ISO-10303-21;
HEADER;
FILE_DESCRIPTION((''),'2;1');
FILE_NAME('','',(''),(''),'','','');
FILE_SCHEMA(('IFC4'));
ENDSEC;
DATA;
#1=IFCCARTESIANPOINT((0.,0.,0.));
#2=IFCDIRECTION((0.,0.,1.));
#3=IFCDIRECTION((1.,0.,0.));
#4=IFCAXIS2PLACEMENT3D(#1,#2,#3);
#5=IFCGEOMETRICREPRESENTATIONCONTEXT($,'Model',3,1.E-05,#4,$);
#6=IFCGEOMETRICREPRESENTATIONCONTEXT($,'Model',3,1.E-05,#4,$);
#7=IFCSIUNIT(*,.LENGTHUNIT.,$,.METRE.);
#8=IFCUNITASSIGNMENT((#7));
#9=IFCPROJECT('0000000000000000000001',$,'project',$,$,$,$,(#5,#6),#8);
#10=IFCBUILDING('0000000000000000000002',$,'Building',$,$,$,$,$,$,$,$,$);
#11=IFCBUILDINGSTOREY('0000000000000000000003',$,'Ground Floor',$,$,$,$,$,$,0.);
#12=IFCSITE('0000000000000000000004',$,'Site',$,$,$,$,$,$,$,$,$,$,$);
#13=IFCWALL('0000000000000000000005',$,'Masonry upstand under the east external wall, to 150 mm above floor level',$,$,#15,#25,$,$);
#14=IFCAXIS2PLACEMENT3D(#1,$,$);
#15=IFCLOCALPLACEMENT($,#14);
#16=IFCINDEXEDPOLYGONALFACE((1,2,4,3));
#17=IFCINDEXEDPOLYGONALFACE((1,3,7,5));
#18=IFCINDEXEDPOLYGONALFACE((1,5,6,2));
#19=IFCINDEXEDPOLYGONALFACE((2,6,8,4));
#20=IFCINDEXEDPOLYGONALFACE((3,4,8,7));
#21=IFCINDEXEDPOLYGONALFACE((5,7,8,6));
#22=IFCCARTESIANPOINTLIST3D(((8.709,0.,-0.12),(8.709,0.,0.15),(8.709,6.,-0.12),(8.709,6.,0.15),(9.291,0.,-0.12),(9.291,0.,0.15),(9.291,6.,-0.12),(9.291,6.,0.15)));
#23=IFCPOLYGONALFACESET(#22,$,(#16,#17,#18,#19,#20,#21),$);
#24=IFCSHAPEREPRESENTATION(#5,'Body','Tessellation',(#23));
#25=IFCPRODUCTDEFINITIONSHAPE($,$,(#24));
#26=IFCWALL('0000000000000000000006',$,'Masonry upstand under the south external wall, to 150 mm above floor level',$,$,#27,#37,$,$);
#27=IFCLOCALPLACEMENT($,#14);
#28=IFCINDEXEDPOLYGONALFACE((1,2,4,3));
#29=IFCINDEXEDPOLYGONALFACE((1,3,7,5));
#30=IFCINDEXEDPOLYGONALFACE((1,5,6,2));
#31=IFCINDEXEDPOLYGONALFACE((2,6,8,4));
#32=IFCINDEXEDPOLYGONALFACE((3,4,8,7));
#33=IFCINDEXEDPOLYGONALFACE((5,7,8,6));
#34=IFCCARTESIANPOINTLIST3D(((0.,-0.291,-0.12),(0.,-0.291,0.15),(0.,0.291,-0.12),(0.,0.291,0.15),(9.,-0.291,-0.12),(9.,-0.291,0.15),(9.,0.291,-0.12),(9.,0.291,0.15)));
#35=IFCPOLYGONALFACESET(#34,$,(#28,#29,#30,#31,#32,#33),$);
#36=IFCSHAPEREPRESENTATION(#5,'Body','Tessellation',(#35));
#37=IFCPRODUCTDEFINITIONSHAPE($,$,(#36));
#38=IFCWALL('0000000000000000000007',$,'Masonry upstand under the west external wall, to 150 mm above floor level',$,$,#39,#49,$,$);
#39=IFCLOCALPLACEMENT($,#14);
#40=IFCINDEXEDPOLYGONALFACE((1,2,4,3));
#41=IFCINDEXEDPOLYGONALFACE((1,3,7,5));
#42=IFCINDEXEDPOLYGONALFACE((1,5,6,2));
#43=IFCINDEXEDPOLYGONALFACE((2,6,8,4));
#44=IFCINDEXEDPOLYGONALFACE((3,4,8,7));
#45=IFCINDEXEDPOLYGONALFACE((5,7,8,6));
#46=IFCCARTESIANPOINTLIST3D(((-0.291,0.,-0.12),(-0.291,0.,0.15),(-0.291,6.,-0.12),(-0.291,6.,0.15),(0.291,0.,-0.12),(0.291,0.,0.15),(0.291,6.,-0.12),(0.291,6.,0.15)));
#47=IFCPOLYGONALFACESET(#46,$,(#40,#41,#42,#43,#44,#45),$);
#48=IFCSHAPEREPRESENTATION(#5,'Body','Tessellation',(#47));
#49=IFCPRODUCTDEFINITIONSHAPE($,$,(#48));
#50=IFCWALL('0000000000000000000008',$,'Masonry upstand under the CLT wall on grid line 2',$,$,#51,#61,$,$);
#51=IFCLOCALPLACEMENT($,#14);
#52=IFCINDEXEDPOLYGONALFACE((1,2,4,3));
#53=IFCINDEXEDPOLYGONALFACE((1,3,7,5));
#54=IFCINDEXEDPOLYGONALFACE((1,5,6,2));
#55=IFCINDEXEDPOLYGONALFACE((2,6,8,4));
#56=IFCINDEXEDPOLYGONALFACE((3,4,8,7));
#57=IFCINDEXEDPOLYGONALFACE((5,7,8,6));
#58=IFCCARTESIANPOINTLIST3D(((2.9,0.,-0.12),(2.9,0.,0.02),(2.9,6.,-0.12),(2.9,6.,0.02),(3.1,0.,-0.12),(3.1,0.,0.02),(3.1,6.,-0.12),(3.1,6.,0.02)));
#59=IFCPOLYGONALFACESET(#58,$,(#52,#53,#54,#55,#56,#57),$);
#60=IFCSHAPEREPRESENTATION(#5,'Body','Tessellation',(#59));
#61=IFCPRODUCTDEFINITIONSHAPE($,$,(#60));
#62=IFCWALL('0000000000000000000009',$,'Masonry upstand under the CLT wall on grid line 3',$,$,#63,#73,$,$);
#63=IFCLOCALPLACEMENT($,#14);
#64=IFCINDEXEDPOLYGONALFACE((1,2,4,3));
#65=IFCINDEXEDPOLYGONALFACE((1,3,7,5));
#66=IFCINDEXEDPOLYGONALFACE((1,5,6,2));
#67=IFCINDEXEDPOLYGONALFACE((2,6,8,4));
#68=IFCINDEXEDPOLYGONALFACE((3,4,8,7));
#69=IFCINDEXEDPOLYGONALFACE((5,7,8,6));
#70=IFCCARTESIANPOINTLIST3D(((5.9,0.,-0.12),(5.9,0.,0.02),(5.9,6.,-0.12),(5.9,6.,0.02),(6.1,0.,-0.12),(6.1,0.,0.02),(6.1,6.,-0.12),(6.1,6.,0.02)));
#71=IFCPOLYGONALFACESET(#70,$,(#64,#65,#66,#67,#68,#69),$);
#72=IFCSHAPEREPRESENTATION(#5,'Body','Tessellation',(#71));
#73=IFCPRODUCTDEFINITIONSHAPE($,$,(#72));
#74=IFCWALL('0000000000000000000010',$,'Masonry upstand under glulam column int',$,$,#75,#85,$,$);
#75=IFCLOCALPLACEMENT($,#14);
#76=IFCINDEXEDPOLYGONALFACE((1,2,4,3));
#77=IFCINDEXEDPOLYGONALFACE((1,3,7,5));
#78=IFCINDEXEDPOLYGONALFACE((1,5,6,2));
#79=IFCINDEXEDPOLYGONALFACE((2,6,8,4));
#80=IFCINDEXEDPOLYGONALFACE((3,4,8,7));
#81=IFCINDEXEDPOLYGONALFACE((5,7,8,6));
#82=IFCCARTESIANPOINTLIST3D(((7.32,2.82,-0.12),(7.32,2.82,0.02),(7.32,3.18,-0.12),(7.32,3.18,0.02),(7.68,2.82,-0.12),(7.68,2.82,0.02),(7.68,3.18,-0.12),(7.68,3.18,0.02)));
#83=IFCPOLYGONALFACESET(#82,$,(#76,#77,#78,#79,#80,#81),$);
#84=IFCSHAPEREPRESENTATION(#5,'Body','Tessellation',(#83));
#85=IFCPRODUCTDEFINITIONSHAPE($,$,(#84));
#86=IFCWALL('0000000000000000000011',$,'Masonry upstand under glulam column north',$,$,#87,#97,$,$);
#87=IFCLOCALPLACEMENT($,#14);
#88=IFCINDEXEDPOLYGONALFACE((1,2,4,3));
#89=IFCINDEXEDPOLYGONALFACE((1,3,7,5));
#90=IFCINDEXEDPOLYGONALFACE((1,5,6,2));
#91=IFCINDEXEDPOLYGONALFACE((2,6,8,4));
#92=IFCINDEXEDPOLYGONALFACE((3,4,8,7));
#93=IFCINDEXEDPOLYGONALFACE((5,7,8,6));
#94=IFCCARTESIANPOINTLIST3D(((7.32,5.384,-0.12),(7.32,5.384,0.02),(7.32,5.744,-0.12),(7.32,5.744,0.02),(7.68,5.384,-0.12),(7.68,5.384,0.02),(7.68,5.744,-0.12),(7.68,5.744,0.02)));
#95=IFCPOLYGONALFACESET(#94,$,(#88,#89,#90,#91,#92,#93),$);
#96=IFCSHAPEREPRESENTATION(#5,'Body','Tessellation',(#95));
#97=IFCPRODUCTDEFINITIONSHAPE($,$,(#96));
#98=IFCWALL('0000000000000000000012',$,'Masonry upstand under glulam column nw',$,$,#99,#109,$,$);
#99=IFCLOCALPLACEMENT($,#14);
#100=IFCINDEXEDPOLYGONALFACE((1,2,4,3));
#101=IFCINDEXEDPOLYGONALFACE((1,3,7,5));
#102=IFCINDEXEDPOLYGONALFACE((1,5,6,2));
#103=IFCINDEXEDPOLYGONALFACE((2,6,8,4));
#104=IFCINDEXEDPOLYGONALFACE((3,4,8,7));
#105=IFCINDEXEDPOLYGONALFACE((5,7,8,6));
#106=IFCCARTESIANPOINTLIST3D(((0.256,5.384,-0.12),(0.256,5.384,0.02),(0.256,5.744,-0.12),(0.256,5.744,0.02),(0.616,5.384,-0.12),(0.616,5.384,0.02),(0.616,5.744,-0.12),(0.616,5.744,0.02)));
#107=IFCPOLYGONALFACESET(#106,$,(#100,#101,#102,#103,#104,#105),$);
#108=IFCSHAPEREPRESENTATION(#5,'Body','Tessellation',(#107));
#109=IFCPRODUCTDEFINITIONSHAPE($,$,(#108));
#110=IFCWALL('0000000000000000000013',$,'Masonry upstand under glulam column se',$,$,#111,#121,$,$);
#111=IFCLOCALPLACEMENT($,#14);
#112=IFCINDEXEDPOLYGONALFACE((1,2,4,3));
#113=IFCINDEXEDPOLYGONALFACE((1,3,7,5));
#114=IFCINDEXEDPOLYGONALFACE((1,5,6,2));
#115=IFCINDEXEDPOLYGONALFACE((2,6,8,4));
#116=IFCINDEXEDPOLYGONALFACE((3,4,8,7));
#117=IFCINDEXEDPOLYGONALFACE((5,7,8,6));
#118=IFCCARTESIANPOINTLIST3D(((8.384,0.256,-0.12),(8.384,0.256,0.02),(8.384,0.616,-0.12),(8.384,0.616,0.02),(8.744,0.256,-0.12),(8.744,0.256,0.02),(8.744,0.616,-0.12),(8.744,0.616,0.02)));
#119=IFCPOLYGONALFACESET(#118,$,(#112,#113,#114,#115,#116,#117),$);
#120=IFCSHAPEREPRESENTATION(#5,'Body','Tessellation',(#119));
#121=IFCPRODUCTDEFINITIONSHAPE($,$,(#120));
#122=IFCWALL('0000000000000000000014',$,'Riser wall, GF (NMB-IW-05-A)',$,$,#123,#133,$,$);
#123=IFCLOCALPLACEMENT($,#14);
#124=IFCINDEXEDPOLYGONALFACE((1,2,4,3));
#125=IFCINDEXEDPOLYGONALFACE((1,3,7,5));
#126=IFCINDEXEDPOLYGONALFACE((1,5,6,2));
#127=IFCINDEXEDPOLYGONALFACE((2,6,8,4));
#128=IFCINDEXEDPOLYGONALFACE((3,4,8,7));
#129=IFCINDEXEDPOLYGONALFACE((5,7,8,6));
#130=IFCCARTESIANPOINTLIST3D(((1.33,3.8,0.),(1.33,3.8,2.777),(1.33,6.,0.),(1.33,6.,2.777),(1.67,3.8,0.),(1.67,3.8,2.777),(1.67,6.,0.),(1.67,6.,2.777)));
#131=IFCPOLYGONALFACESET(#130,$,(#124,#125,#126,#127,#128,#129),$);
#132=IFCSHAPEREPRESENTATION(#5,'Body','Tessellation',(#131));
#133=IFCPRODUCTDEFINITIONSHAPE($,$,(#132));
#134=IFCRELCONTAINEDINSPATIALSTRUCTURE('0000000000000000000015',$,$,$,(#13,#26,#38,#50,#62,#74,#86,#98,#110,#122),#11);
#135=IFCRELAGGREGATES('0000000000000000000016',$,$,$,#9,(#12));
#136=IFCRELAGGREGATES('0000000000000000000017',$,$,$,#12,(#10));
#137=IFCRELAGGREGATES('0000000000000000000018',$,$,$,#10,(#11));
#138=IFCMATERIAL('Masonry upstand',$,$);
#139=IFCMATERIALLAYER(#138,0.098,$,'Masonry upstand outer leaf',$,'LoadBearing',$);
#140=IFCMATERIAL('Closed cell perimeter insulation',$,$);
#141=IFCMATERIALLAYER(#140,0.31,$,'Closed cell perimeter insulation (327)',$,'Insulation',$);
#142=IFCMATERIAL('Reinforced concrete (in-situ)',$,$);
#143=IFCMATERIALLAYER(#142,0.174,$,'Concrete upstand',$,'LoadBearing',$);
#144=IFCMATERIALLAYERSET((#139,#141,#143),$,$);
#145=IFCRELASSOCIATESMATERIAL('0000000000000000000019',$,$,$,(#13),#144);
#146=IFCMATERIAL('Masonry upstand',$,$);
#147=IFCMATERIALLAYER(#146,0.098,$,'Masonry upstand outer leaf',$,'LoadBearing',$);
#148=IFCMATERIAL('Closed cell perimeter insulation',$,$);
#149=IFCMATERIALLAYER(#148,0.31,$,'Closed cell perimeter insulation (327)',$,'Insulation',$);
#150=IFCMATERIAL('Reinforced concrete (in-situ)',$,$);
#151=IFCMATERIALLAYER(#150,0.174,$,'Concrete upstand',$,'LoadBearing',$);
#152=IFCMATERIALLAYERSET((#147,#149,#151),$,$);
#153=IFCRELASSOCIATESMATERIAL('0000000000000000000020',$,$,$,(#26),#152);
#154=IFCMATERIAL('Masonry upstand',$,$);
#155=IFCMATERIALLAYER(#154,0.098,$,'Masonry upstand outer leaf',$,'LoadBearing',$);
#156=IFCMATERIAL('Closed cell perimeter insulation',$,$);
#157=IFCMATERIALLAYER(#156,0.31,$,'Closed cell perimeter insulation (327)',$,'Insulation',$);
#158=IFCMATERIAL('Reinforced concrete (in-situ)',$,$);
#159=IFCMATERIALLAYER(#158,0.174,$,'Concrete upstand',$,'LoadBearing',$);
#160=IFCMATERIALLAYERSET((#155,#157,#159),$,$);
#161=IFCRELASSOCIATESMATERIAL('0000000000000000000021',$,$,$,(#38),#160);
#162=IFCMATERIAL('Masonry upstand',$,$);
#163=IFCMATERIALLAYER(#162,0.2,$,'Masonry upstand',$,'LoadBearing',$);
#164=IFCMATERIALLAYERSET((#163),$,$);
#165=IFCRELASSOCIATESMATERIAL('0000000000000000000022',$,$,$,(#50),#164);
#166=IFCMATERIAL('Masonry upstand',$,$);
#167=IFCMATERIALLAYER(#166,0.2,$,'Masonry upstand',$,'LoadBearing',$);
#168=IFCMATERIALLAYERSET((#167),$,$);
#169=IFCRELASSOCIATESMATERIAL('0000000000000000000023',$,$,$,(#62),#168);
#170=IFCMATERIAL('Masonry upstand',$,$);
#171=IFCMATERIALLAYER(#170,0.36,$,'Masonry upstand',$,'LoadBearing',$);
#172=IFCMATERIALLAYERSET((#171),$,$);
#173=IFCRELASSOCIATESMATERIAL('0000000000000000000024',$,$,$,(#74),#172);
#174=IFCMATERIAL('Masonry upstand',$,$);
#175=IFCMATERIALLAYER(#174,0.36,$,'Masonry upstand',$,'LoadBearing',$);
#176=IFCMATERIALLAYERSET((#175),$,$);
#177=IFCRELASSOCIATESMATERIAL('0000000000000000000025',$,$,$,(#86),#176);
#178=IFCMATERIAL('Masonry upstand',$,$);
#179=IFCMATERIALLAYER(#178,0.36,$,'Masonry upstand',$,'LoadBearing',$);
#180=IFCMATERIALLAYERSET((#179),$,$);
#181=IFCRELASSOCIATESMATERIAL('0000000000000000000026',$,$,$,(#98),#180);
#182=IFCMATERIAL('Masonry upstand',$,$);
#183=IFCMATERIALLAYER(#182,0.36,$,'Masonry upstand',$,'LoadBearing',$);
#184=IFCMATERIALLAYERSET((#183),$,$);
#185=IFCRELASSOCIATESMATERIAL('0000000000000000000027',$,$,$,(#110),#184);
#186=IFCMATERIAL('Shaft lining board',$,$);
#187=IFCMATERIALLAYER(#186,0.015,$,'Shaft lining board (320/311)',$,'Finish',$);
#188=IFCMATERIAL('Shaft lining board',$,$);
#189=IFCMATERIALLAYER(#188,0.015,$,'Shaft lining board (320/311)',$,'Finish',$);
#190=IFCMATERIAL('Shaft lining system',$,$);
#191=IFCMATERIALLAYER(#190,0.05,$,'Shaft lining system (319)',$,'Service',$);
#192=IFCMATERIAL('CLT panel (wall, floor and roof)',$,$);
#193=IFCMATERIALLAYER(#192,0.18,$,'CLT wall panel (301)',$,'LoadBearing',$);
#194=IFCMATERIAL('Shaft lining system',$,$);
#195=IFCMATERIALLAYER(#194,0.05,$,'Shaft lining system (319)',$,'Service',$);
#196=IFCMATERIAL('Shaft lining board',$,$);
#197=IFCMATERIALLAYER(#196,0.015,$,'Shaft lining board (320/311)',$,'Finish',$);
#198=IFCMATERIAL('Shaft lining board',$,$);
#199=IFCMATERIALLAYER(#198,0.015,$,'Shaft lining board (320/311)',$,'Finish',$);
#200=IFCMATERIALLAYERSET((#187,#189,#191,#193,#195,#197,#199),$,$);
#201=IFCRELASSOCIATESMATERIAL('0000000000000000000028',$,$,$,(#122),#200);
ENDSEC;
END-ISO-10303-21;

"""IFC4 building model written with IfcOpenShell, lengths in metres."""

from ifc_helpers import new_model, si_unit, frame, frame_2d, origin_with_axes, place, context, project, spatial, rectangle, extrude, material, layer, layer_set, layer_usage, element, save


model = new_model("IFC4")

# Units and contexts
model_context_1 = context("Model", 3, precision=1e-05, world=origin_with_axes())
model_context_2 = context("Model", 3, precision=1e-05, world=origin_with_axes())
ifc_project = project(units=[si_unit("LENGTHUNIT", "METRE")], contexts=[model_context_1, model_context_2])

# Site, building, storey
site = spatial("IfcSite", under=ifc_project, Name="Site")
building = spatial("IfcBuilding", under=site, Name="Building")
storey = spatial("IfcBuildingStorey", under=building, Name="Ground Floor", Elevation=0.0)

# Walls
ifc_material_1 = material(Name="Masonry upstand")
ifc_layer_1 = layer(ifc_material_1, 0.098, Name="Masonry upstand outer leaf", Category="LoadBearing")
ifc_material_2 = material(Name="Closed cell perimeter insulation")
ifc_layer_2 = layer(ifc_material_2, 0.31, Name="Closed cell perimeter insulation (327)", Category="Insulation")
ifc_material_3 = material(Name="Reinforced concrete (in-situ)")
ifc_layer_3 = layer(ifc_material_3, 0.174, Name="Concrete upstand", Category="LoadBearing")
ifc_layer_set_1 = layer_set([ifc_layer_1, ifc_layer_2, ifc_layer_3])
ifc_layer_usage_1 = layer_usage(ifc_layer_set_1, "AXIS2", "NEGATIVE", 0.291)
wall_1_placement = place(None, frame((9.0, 6.0, -0.12), z_axis=(0.0, 0.0, 1.0), x_axis=(0.0, -1.0, 0.0)))
element("IfcWall", 1, at=wall_1_placement, inside=storey, material=ifc_layer_usage_1, Name="Masonry upstand under the east external wall, to 150 mm above floor level", context=model_context_1, shape_type="SweptSolid", body=[
    extrude(rectangle(XDim=0.582, YDim=0.27, at=frame_2d((0.0, 0.135))), frame((0.0, 0.0, 0.0), z_axis=(1.0, 0.0, 0.0), x_axis=(0.0, 1.0, 0.0)), (0.0, 0.0, 1.0), 6.0),
])
ifc_material_4 = material(Name="Masonry upstand")
ifc_layer_4 = layer(ifc_material_4, 0.098, Name="Masonry upstand outer leaf", Category="LoadBearing")
ifc_material_5 = material(Name="Closed cell perimeter insulation")
ifc_layer_5 = layer(ifc_material_5, 0.31, Name="Closed cell perimeter insulation (327)", Category="Insulation")
ifc_material_6 = material(Name="Reinforced concrete (in-situ)")
ifc_layer_6 = layer(ifc_material_6, 0.174, Name="Concrete upstand", Category="LoadBearing")
ifc_layer_set_2 = layer_set([ifc_layer_4, ifc_layer_5, ifc_layer_6])
ifc_layer_usage_2 = layer_usage(ifc_layer_set_2, "AXIS2", "NEGATIVE", 0.291)
wall_2_placement = place(None, frame((9.0, 0.0, -0.12), z_axis=(0.0, 0.0, 1.0), x_axis=(-1.0, 0.0, 0.0)))
element("IfcWall", 2, at=wall_2_placement, inside=storey, material=ifc_layer_usage_2, Name="Masonry upstand under the south external wall, to 150 mm above floor level", context=model_context_1, shape_type="SweptSolid", body=[
    extrude(rectangle(XDim=0.582, YDim=0.27, at=frame_2d((0.0, 0.135))), frame((0.0, 0.0, 0.0), z_axis=(1.0, 0.0, 0.0), x_axis=(0.0, 1.0, 0.0)), (0.0, 0.0, 1.0), 9.0),
])
ifc_material_7 = material(Name="Masonry upstand")
ifc_layer_7 = layer(ifc_material_7, 0.098, Name="Masonry upstand outer leaf", Category="LoadBearing")
ifc_material_8 = material(Name="Closed cell perimeter insulation")
ifc_layer_8 = layer(ifc_material_8, 0.31, Name="Closed cell perimeter insulation (327)", Category="Insulation")
ifc_material_9 = material(Name="Reinforced concrete (in-situ)")
ifc_layer_9 = layer(ifc_material_9, 0.174, Name="Concrete upstand", Category="LoadBearing")
ifc_layer_set_3 = layer_set([ifc_layer_7, ifc_layer_8, ifc_layer_9])
ifc_layer_usage_3 = layer_usage(ifc_layer_set_3, "AXIS2", "NEGATIVE", 0.291)
wall_3_placement = place(None, frame((0.0, 0.0, -0.12), z_axis=(0.0, 0.0, 1.0), x_axis=(0.0, 1.0, 0.0)))
element("IfcWall", 3, at=wall_3_placement, inside=storey, material=ifc_layer_usage_3, Name="Masonry upstand under the west external wall, to 150 mm above floor level", context=model_context_1, shape_type="SweptSolid", body=[
    extrude(rectangle(XDim=0.582, YDim=0.27, at=frame_2d((0.0, 0.135))), frame((0.0, 0.0, 0.0), z_axis=(1.0, 0.0, 0.0), x_axis=(0.0, 1.0, 0.0)), (0.0, 0.0, 1.0), 6.0),
])
ifc_material_10 = material(Name="Masonry upstand")
ifc_layer_10 = layer(ifc_material_10, 0.2, Name="Masonry upstand", Category="LoadBearing")
ifc_layer_set_4 = layer_set([ifc_layer_10])
ifc_layer_usage_4 = layer_usage(ifc_layer_set_4, "AXIS2", "NEGATIVE", 0.1)
wall_4_placement = place(None, frame((3.0, 0.0, -0.12), z_axis=(0.0, 0.0, 1.0), x_axis=(0.0, 1.0, 0.0)))
element("IfcWall", 4, at=wall_4_placement, inside=storey, material=ifc_layer_usage_4, Name="Masonry upstand under the CLT wall on grid line 2", context=model_context_1, shape_type="SweptSolid", body=[
    extrude(rectangle(XDim=0.2, YDim=0.14, at=frame_2d((0.0, 0.07))), frame((0.0, 0.0, 0.0), z_axis=(1.0, 0.0, 0.0), x_axis=(0.0, 1.0, 0.0)), (0.0, 0.0, 1.0), 6.0),
])
ifc_material_11 = material(Name="Masonry upstand")
ifc_layer_11 = layer(ifc_material_11, 0.2, Name="Masonry upstand", Category="LoadBearing")
ifc_layer_set_5 = layer_set([ifc_layer_11])
ifc_layer_usage_5 = layer_usage(ifc_layer_set_5, "AXIS2", "NEGATIVE", 0.1)
wall_5_placement = place(None, frame((6.0, 0.0, -0.12), z_axis=(0.0, 0.0, 1.0), x_axis=(0.0, 1.0, 0.0)))
element("IfcWall", 5, at=wall_5_placement, inside=storey, material=ifc_layer_usage_5, Name="Masonry upstand under the CLT wall on grid line 3", context=model_context_1, shape_type="SweptSolid", body=[
    extrude(rectangle(XDim=0.2, YDim=0.14, at=frame_2d((0.0, 0.07))), frame((0.0, 0.0, 0.0), z_axis=(1.0, 0.0, 0.0), x_axis=(0.0, 1.0, 0.0)), (0.0, 0.0, 1.0), 6.0),
])
ifc_material_12 = material(Name="Masonry upstand")
ifc_layer_12 = layer(ifc_material_12, 0.36, Name="Masonry upstand", Category="LoadBearing")
ifc_layer_set_6 = layer_set([ifc_layer_12])
ifc_layer_usage_6 = layer_usage(ifc_layer_set_6, "AXIS2", "NEGATIVE", 0.18)
wall_6_placement = place(None, frame((7.32, 3.0, -0.12), z_axis=(0.0, 0.0, 1.0), x_axis=(1.0, 0.0, 0.0)))
element("IfcWall", 6, at=wall_6_placement, inside=storey, material=ifc_layer_usage_6, Name="Masonry upstand under glulam column int", context=model_context_1, shape_type="SweptSolid", body=[
    extrude(rectangle(XDim=0.36, YDim=0.14, at=frame_2d((0.0, 0.07))), frame((0.0, 0.0, 0.0), z_axis=(1.0, 0.0, 0.0), x_axis=(0.0, 1.0, 0.0)), (0.0, 0.0, 1.0), 0.36),
])
ifc_material_13 = material(Name="Masonry upstand")
ifc_layer_13 = layer(ifc_material_13, 0.36, Name="Masonry upstand", Category="LoadBearing")
ifc_layer_set_7 = layer_set([ifc_layer_13])
ifc_layer_usage_7 = layer_usage(ifc_layer_set_7, "AXIS2", "NEGATIVE", 0.18)
wall_7_placement = place(None, frame((7.32, 5.564, -0.12), z_axis=(0.0, 0.0, 1.0), x_axis=(1.0, 0.0, 0.0)))
element("IfcWall", 7, at=wall_7_placement, inside=storey, material=ifc_layer_usage_7, Name="Masonry upstand under glulam column north", context=model_context_1, shape_type="SweptSolid", body=[
    extrude(rectangle(XDim=0.36, YDim=0.14, at=frame_2d((0.0, 0.07))), frame((0.0, 0.0, 0.0), z_axis=(1.0, 0.0, 0.0), x_axis=(0.0, 1.0, 0.0)), (0.0, 0.0, 1.0), 0.36),
])
ifc_material_14 = material(Name="Masonry upstand")
ifc_layer_14 = layer(ifc_material_14, 0.36, Name="Masonry upstand", Category="LoadBearing")
ifc_layer_set_8 = layer_set([ifc_layer_14])
ifc_layer_usage_8 = layer_usage(ifc_layer_set_8, "AXIS2", "NEGATIVE", 0.18)
wall_8_placement = place(None, frame((0.256, 5.564, -0.12), z_axis=(0.0, 0.0, 1.0), x_axis=(1.0, 0.0, 0.0)))
element("IfcWall", 8, at=wall_8_placement, inside=storey, material=ifc_layer_usage_8, Name="Masonry upstand under glulam column nw", context=model_context_1, shape_type="SweptSolid", body=[
    extrude(rectangle(XDim=0.36, YDim=0.14, at=frame_2d((0.0, 0.07))), frame((0.0, 0.0, 0.0), z_axis=(1.0, 0.0, 0.0), x_axis=(0.0, 1.0, 0.0)), (0.0, 0.0, 1.0), 0.36),
])
ifc_material_15 = material(Name="Masonry upstand")
ifc_layer_15 = layer(ifc_material_15, 0.36, Name="Masonry upstand", Category="LoadBearing")
ifc_layer_set_9 = layer_set([ifc_layer_15])
ifc_layer_usage_9 = layer_usage(ifc_layer_set_9, "AXIS2", "NEGATIVE", 0.18)
wall_9_placement = place(None, frame((8.384, 0.436, -0.12), z_axis=(0.0, 0.0, 1.0), x_axis=(1.0, 0.0, 0.0)))
element("IfcWall", 9, at=wall_9_placement, inside=storey, material=ifc_layer_usage_9, Name="Masonry upstand under glulam column se", context=model_context_1, shape_type="SweptSolid", body=[
    extrude(rectangle(XDim=0.36, YDim=0.14, at=frame_2d((0.0, 0.07))), frame((0.0, 0.0, 0.0), z_axis=(1.0, 0.0, 0.0), x_axis=(0.0, 1.0, 0.0)), (0.0, 0.0, 1.0), 0.36),
])
ifc_material_16 = material(Name="Shaft lining board")
ifc_layer_16 = layer(ifc_material_16, 0.015, Name="Shaft lining board (320/311)", Category="Finish")
ifc_material_17 = material(Name="Shaft lining board")
ifc_layer_17 = layer(ifc_material_17, 0.015, Name="Shaft lining board (320/311)", Category="Finish")
ifc_material_18 = material(Name="Shaft lining system")
ifc_layer_18 = layer(ifc_material_18, 0.05, Name="Shaft lining system (319)", Category="Service")
ifc_material_19 = material(Name="CLT panel (wall, floor and roof)")
ifc_layer_19 = layer(ifc_material_19, 0.18, Name="CLT wall panel (301)", Category="LoadBearing")
ifc_material_20 = material(Name="Shaft lining system")
ifc_layer_20 = layer(ifc_material_20, 0.05, Name="Shaft lining system (319)", Category="Service")
ifc_material_21 = material(Name="Shaft lining board")
ifc_layer_21 = layer(ifc_material_21, 0.015, Name="Shaft lining board (320/311)", Category="Finish")
ifc_material_22 = material(Name="Shaft lining board")
ifc_layer_22 = layer(ifc_material_22, 0.015, Name="Shaft lining board (320/311)", Category="Finish")
ifc_layer_set_10 = layer_set([ifc_layer_16, ifc_layer_17, ifc_layer_18, ifc_layer_19, ifc_layer_20, ifc_layer_21, ifc_layer_22])
ifc_layer_usage_10 = layer_usage(ifc_layer_set_10, "AXIS2", "NEGATIVE", 0.17)
wall_10_placement = place(None, frame((1.5, 3.8, 0.0), z_axis=(0.0, 0.0, 1.0), x_axis=(0.0, 1.0, 0.0)))
element("IfcWall", 10, at=wall_10_placement, inside=storey, material=ifc_layer_usage_10, Name="Riser wall, GF (NMB-IW-05-A)", context=model_context_1, shape_type="SweptSolid", body=[
    extrude(rectangle(XDim=0.34, YDim=2.777, at=frame_2d((0.0, 1.3885))), frame((0.0, 0.0, 0.0), z_axis=(1.0, 0.0, 0.0), x_axis=(0.0, 1.0, 0.0)), (0.0, 0.0, 1.0), 2.2),
])

save(model, "model.ifc")
